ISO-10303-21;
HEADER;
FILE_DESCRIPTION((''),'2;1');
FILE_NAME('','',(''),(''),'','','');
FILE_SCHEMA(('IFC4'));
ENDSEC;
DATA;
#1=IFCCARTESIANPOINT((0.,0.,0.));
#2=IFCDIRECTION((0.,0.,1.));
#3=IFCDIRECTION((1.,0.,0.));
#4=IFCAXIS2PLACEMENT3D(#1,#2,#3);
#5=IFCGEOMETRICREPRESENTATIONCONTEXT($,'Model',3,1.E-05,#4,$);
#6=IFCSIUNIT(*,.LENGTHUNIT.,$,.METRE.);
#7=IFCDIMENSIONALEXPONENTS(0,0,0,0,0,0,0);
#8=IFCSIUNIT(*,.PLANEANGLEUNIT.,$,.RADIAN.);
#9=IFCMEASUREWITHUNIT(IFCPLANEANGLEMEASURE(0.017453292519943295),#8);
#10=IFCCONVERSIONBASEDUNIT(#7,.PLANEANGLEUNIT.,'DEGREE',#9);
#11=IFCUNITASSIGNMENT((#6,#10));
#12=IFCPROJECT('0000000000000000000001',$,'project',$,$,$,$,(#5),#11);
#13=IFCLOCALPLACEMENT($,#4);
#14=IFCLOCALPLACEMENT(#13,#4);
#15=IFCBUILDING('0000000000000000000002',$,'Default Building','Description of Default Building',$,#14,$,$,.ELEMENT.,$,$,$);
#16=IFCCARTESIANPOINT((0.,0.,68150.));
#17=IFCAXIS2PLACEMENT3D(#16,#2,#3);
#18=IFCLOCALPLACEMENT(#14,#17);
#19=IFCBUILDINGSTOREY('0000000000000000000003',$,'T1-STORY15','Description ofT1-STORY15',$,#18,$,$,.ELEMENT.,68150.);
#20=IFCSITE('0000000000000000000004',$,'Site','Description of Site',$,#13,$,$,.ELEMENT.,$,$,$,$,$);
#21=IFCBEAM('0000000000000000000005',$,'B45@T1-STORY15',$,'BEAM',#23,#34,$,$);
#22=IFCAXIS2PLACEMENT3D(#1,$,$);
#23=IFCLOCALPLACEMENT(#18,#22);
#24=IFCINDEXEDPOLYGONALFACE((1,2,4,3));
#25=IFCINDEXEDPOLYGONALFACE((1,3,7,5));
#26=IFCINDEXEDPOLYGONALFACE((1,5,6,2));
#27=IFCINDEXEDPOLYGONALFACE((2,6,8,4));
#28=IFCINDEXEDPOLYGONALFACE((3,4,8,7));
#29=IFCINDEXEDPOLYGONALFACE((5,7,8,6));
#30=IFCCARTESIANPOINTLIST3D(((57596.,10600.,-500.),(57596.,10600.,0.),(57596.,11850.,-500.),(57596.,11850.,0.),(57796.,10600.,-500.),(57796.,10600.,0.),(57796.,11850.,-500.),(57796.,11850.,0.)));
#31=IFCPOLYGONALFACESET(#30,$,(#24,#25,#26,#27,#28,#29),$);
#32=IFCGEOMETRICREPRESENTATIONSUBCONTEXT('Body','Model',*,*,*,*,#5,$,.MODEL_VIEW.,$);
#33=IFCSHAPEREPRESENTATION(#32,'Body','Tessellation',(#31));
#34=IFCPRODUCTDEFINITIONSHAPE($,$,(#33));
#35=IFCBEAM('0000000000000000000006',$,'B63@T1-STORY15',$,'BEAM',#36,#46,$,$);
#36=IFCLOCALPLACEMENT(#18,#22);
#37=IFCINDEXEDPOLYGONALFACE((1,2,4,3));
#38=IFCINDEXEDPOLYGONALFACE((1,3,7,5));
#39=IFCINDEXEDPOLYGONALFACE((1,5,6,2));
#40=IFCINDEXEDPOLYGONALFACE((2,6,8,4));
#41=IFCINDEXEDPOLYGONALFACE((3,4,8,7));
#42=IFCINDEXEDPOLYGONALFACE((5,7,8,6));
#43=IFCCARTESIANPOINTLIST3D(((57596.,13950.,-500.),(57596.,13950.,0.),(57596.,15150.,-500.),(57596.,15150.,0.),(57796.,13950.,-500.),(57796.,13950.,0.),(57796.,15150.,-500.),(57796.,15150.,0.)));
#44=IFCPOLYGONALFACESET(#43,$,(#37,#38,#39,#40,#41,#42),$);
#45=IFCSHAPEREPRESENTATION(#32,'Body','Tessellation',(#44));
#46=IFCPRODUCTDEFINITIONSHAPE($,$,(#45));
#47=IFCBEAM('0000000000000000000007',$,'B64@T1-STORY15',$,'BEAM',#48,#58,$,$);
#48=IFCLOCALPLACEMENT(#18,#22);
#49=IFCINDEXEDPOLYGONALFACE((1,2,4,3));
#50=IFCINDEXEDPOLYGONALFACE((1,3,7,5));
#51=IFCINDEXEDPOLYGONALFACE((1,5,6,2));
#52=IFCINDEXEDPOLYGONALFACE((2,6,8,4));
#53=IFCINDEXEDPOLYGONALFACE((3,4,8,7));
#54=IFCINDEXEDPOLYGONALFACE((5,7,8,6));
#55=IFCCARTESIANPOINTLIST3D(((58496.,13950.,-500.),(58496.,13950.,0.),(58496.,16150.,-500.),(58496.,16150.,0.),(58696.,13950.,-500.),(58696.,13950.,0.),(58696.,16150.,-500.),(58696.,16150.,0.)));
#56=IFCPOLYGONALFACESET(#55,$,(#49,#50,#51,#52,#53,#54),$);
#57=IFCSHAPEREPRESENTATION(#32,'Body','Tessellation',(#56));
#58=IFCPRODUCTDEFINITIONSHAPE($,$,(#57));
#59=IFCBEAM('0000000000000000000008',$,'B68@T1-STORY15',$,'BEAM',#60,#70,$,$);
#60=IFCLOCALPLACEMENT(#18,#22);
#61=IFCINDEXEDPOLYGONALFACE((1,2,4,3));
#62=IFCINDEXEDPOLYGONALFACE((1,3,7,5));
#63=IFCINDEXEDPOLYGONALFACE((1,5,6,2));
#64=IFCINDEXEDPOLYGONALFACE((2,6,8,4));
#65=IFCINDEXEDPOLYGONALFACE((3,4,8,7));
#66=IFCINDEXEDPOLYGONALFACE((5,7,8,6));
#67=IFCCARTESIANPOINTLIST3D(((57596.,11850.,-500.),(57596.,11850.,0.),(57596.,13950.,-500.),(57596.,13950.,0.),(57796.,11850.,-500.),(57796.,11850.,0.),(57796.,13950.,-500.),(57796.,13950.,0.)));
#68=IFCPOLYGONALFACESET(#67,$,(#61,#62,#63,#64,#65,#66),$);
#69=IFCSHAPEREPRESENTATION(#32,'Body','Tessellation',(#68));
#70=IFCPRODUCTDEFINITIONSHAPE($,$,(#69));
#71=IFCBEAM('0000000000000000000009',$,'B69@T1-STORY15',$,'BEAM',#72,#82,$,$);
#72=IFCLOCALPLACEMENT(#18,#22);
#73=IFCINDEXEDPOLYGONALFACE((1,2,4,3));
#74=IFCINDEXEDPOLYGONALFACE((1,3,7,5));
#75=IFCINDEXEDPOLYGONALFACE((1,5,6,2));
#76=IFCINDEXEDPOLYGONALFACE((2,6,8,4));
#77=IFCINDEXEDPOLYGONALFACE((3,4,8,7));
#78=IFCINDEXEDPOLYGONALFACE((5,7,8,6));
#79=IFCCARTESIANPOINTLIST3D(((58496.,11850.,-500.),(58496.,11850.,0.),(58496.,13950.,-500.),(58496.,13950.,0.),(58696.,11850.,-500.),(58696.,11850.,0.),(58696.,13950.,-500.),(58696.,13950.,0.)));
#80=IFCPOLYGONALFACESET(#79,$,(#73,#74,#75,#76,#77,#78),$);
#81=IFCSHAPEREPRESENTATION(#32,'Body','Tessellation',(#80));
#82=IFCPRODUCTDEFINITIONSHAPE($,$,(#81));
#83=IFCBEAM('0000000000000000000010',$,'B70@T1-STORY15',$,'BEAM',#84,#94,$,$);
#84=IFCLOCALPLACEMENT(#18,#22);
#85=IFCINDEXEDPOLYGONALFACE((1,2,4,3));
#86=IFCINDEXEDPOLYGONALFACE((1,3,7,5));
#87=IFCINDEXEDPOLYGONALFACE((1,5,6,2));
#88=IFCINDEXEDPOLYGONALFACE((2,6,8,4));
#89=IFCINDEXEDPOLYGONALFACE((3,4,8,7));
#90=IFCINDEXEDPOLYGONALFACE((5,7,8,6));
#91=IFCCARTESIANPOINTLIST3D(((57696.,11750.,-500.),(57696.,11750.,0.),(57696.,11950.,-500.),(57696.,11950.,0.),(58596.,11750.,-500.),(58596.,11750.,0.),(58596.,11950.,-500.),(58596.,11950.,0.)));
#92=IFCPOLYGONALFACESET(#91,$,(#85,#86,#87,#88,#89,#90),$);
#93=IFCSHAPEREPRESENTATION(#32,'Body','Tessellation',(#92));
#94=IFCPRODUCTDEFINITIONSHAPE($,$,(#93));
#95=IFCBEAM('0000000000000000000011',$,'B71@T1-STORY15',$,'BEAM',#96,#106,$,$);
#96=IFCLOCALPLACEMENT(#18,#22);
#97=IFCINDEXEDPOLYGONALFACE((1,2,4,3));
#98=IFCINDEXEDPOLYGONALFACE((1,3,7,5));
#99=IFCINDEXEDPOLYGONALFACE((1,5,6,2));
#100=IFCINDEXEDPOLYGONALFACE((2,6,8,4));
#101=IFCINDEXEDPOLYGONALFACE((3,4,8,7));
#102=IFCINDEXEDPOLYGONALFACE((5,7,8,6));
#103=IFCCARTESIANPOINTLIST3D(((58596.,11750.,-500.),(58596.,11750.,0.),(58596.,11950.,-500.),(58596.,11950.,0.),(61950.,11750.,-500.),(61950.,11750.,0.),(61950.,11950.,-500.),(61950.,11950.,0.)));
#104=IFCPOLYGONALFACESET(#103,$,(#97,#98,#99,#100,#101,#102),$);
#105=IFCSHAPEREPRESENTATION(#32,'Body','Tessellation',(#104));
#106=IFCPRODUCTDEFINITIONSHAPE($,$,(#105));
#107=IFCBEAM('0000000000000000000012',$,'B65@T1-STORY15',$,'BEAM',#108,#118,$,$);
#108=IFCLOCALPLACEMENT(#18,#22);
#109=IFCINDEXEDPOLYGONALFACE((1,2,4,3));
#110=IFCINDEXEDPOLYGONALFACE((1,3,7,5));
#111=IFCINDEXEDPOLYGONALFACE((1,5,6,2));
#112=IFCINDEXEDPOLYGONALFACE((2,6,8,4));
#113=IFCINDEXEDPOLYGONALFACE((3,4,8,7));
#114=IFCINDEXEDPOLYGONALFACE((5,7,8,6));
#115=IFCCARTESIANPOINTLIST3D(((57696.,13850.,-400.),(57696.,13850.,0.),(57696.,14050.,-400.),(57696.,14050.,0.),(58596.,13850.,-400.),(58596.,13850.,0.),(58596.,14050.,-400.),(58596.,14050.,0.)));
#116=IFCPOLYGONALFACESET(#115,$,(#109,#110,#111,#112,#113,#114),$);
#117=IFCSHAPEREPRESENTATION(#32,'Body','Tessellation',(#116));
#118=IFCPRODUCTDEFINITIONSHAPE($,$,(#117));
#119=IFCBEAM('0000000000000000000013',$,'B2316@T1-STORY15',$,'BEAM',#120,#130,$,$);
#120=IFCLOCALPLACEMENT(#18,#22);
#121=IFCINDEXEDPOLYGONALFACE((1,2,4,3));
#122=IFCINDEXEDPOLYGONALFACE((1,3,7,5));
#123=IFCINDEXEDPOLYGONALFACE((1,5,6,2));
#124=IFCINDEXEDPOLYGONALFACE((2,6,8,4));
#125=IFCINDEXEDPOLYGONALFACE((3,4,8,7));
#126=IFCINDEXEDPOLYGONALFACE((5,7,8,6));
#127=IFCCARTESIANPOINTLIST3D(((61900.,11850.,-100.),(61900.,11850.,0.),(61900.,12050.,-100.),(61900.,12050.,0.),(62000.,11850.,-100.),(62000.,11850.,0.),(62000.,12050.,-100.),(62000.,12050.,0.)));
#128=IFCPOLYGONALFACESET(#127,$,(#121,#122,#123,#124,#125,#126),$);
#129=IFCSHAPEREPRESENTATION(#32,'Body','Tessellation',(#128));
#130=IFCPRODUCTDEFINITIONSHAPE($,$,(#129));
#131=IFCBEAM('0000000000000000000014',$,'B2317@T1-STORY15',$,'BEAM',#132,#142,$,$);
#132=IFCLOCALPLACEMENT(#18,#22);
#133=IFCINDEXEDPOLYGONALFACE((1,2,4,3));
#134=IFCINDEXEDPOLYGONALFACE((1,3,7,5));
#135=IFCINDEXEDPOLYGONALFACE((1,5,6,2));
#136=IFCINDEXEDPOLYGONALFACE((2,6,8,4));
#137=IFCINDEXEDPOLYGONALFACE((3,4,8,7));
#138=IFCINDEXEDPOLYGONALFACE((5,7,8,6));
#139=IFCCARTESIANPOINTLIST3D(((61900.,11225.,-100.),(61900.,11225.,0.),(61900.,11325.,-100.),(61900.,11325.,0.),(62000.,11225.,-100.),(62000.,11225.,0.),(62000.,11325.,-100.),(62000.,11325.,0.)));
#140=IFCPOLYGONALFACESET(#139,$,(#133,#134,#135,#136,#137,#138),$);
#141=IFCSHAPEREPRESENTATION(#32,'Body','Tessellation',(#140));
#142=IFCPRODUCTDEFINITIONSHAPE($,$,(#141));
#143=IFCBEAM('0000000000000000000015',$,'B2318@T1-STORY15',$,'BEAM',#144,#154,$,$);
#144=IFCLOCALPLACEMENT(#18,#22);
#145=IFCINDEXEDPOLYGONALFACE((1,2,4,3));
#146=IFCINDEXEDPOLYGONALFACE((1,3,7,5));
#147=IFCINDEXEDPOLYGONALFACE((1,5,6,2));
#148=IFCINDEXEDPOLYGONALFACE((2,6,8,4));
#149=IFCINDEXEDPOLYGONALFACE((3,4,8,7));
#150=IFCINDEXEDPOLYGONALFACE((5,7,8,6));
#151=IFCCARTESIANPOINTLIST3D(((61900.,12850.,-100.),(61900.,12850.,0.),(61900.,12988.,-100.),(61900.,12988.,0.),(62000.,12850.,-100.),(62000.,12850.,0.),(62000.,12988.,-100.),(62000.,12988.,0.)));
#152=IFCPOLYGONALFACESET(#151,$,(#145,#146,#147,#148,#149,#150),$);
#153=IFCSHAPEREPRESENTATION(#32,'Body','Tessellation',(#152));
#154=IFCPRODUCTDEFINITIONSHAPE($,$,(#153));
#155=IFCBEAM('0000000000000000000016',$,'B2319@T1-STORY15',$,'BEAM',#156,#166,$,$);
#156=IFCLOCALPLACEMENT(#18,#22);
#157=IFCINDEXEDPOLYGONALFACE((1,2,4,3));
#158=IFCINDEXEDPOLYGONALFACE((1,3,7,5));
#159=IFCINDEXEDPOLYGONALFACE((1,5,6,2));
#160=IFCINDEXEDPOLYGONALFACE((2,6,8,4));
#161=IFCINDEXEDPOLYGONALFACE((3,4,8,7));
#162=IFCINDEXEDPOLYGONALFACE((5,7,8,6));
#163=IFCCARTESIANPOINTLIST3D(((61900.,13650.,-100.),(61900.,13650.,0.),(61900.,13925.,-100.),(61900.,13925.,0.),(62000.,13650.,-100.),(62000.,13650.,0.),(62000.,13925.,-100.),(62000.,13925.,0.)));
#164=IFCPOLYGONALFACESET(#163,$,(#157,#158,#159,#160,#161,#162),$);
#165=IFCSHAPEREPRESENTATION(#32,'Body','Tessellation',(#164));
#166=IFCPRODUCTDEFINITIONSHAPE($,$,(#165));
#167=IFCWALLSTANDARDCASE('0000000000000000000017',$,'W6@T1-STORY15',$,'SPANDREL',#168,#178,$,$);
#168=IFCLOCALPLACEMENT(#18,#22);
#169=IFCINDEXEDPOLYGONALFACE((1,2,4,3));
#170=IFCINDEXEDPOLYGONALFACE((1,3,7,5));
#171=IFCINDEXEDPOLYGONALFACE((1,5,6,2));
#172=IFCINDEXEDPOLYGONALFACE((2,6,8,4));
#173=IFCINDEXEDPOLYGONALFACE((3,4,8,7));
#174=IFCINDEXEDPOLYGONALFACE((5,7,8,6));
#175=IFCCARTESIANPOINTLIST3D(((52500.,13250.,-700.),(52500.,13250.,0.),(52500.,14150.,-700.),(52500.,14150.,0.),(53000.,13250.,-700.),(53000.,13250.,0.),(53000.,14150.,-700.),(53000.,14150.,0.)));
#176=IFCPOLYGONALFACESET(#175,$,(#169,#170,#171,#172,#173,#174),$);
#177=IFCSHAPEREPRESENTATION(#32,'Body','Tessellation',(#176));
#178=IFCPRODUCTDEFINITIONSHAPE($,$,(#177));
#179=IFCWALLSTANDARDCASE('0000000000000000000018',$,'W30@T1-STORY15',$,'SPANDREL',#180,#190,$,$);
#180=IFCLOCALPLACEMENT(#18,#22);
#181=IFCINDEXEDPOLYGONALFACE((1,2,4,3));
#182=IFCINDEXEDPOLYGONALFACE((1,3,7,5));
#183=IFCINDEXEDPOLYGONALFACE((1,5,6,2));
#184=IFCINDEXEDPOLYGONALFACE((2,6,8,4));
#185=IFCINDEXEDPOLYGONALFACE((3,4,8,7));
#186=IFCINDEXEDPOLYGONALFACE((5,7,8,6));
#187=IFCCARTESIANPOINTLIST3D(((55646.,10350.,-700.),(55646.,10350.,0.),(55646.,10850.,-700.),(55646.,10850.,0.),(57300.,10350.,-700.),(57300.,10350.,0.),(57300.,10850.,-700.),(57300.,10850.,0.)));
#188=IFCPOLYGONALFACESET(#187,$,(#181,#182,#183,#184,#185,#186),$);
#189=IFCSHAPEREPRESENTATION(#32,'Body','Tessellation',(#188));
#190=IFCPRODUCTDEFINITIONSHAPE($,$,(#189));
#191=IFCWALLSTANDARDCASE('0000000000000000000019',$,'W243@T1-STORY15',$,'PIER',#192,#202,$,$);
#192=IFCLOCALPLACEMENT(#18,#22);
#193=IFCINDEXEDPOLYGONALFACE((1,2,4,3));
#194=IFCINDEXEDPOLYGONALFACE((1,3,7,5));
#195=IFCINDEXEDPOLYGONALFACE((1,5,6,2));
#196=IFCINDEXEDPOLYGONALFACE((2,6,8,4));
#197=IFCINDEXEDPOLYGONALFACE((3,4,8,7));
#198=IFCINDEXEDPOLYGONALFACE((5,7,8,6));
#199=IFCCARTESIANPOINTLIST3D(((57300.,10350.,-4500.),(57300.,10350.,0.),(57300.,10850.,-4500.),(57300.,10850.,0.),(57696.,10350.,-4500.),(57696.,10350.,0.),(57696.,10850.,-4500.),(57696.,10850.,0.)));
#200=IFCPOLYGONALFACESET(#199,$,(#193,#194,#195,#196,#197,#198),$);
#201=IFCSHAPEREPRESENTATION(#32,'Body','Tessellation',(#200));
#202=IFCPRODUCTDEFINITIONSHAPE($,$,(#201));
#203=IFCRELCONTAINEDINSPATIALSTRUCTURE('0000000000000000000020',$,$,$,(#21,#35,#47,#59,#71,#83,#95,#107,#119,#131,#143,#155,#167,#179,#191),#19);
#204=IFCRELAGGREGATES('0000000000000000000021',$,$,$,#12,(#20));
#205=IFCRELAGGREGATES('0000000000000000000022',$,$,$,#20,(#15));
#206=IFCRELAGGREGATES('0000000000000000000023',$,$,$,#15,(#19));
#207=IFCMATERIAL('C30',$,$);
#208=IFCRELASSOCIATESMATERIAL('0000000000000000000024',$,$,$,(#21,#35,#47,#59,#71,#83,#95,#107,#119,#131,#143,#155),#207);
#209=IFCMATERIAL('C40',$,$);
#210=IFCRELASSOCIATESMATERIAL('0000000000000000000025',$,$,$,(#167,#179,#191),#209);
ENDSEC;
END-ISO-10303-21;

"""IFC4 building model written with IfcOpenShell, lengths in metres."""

from ifc_helpers import new_model, entity, si_unit, converted_unit, frame, origin_with_axes, place, context, subcontext, project, spatial, indexed_curve, rectangle, outline, extrude, material, element, save


model = new_model("IFC4")

# Units and contexts
model_context = context("Model", 3, precision=1e-05, world=origin_with_axes())
body_context = subcontext(model_context, "Body", "Model", "MODEL_VIEW")
ifc_project = project(units=[si_unit("LENGTHUNIT", "METRE"), converted_unit("PLANEANGLEUNIT", "DEGREE", entity("IfcPlaneAngleMeasure", 0.017453292519943295), si_unit("PLANEANGLEUNIT", "RADIAN"), dimensions=[0, 0, 0, 0, 0, 0, 0])], contexts=[model_context])

# Site, building, storey
site_placement = place(None, origin_with_axes())
site = spatial("IfcSite", under=ifc_project, at=site_placement, Name="Site", Description="Description of Site", CompositionType="ELEMENT")
building_placement = place(site_placement, origin_with_axes())
building = spatial("IfcBuilding", under=site, at=building_placement, Name="Default Building", Description="Description of Default Building", CompositionType="ELEMENT")
storey_placement = place(building_placement, frame((0.0, 0.0, 68150.0), z_axis=(0.0, 0.0, 1.0), x_axis=(1.0, 0.0, 0.0)))
storey = spatial("IfcBuildingStorey", under=building, at=storey_placement, Name="T1-STORY15", Description="Description ofT1-STORY15", CompositionType="ELEMENT", Elevation=68150.0)

# Beams
ifc_material_1 = material(Name="C30")
beam_1_placement = place(storey_placement, frame((57696.0, 10600.0, -250.0), z_axis=(0.0, 1.0, 0.0), x_axis=(-1.0, 0.0, 0.0)))
element("IfcBeam", 1, at=beam_1_placement, inside=storey, material=ifc_material_1, Name="B45@T1-STORY15", ObjectType="BEAM", context=body_context, shape_type="SweptSolid", body=[
    extrude(rectangle(XDim=200.0, YDim=500.0), origin_with_axes(), (0.0, 0.0, 1.0), 1250.0),
])
beam_2_placement = place(storey_placement, frame((57696.0, 13950.0, -250.0), z_axis=(0.0, 1.0, 0.0), x_axis=(-1.0, 0.0, 0.0)))
element("IfcBeam", 2, at=beam_2_placement, inside=storey, material=ifc_material_1, Name="B63@T1-STORY15", ObjectType="BEAM", context=body_context, shape_type="SweptSolid", body=[
    extrude(rectangle(XDim=200.0, YDim=500.0), origin_with_axes(), (0.0, 0.0, 1.0), 1200.0),
])
beam_3_placement = place(storey_placement, frame((58596.0, 13950.0, -250.0), z_axis=(0.0, 1.0, 0.0), x_axis=(-1.0, 0.0, 0.0)))
element("IfcBeam", 3, at=beam_3_placement, inside=storey, material=ifc_material_1, Name="B64@T1-STORY15", ObjectType="BEAM", context=body_context, shape_type="SweptSolid", body=[
    extrude(rectangle(XDim=200.0, YDim=500.0), origin_with_axes(), (0.0, 0.0, 1.0), 2200.0),
])
for number, where, z_axis, x_axis, name in (
    (4, (57696.0, 11850.0, -250.0), (0.0, 1.0, 0.0), (-1.0, 0.0, 0.0), "B68@T1-STORY15"),
    (5, (58596.0, 11850.0, -250.0), (0.0, 1.0, 0.0), (-1.0, 0.0, 0.0), "B69@T1-STORY15"),
):
    element("IfcBeam", number, at=place(storey_placement, frame(where, z_axis=z_axis, x_axis=x_axis)), inside=storey, material=ifc_material_1, Name=name, ObjectType="BEAM", context=body_context, shape_type="SweptSolid", body=[
        extrude(rectangle(XDim=200.0, YDim=500.0), origin_with_axes(), (0.0, 0.0, 1.0), 2100.0),
    ])
beam_4_placement = place(storey_placement, frame((57696.0, 11850.0, -250.0), z_axis=(1.0, 0.0, 0.0), x_axis=(0.0, 1.0, 0.0)))
element("IfcBeam", 6, at=beam_4_placement, inside=storey, material=ifc_material_1, Name="B70@T1-STORY15", ObjectType="BEAM", context=body_context, shape_type="SweptSolid", body=[
    extrude(rectangle(XDim=200.0, YDim=500.0), origin_with_axes(), (0.0, 0.0, 1.0), 900.0),
])
beam_5_placement = place(storey_placement, frame((58596.0, 11850.0, -250.0), z_axis=(1.0, 0.0, 0.0), x_axis=(0.0, 1.0, 0.0)))
element("IfcBeam", 7, at=beam_5_placement, inside=storey, material=ifc_material_1, Name="B71@T1-STORY15", ObjectType="BEAM", context=body_context, shape_type="SweptSolid", body=[
    extrude(rectangle(XDim=200.0, YDim=500.0), origin_with_axes(), (0.0, 0.0, 1.0), 3354.0),
])
beam_6_placement = place(storey_placement, frame((57696.0, 13950.0, -200.0), z_axis=(1.0, 0.0, 0.0), x_axis=(0.0, 1.0, 0.0)))
element("IfcBeam", 8, at=beam_6_placement, inside=storey, material=ifc_material_1, Name="B65@T1-STORY15", ObjectType="BEAM", context=body_context, shape_type="SweptSolid", body=[
    extrude(rectangle(XDim=200.0, YDim=400.0), origin_with_axes(), (0.0, 0.0, 1.0), 900.0),
])
beam_7_placement = place(storey_placement, frame((61950.0, 11850.0, -50.0), z_axis=(0.0, 1.0, 0.0), x_axis=(-1.0, 0.0, 0.0)))
element("IfcBeam", 9, at=beam_7_placement, inside=storey, material=ifc_material_1, Name="B2316@T1-STORY15", ObjectType="BEAM", context=body_context, shape_type="SweptSolid", body=[
    extrude(rectangle(XDim=100.0, YDim=100.0), origin_with_axes(), (0.0, 0.0, 1.0), 200.0),
])
beam_8_placement = place(storey_placement, frame((61950.0, 11225.0, -50.0), z_axis=(0.0, 1.0, 0.0), x_axis=(-1.0, 0.0, 0.0)))
element("IfcBeam", 10, at=beam_8_placement, inside=storey, material=ifc_material_1, Name="B2317@T1-STORY15", ObjectType="BEAM", context=body_context, shape_type="SweptSolid", body=[
    extrude(rectangle(XDim=100.0, YDim=100.0), origin_with_axes(), (0.0, 0.0, 1.0), 100.0),
])
beam_9_placement = place(storey_placement, frame((61950.0, 12850.0, -50.0), z_axis=(0.0, 1.0, 0.0), x_axis=(-1.0, 0.0, 0.0)))
element("IfcBeam", 11, at=beam_9_placement, inside=storey, material=ifc_material_1, Name="B2318@T1-STORY15", ObjectType="BEAM", context=body_context, shape_type="SweptSolid", body=[
    extrude(rectangle(XDim=100.0, YDim=100.0), origin_with_axes(), (0.0, 0.0, 1.0), 138.0),
])
beam_10_placement = place(storey_placement, frame((61950.0, 13650.0, -50.0), z_axis=(0.0, 1.0, 0.0), x_axis=(-1.0, 0.0, 0.0)))
element("IfcBeam", 12, at=beam_10_placement, inside=storey, material=ifc_material_1, Name="B2319@T1-STORY15", ObjectType="BEAM", context=body_context, shape_type="SweptSolid", body=[
    extrude(rectangle(XDim=100.0, YDim=100.0), origin_with_axes(), (0.0, 0.0, 1.0), 275.0),
])

# Walls
ifc_material_2 = material(Name="C40")
wall_1_placement = place(storey_placement, frame((52750.0, 13250.0, -700.0), z_axis=(0.0, 0.0, 1.0), x_axis=(0.0, 1.0, 0.0)))
element("IfcWallStandardCase", 13, at=wall_1_placement, inside=storey, material=ifc_material_2, Name="W6@T1-STORY15", ObjectType="SPANDREL", context=body_context, shape_type="SweptSolid", body=[
    extrude(outline(indexed_curve([(0.0, -250.0), (0.0, 250.0), (900.0, 250.0), (900.0, -250.0), (0.0, -250.0)], self_intersect=False)), origin_with_axes(), (0.0, 0.0, 1.0), 700.0),
])
wall_2_placement = place(storey_placement, frame((55646.0, 10600.0, -700.0), z_axis=(0.0, 0.0, 1.0), x_axis=(1.0, 0.0, 0.0)))
element("IfcWallStandardCase", 14, at=wall_2_placement, inside=storey, material=ifc_material_2, Name="W30@T1-STORY15", ObjectType="SPANDREL", context=body_context, shape_type="SweptSolid", body=[
    extrude(outline(indexed_curve([(0.0, -250.0), (0.0, 250.0), (1654.0, 250.0), (1654.0, -250.0), (0.0, -250.0)], self_intersect=False)), origin_with_axes(), (0.0, 0.0, 1.0), 700.0),
])
wall_3_placement = place(storey_placement, frame((57300.0, 10600.0, -4500.0), z_axis=(0.0, 0.0, 1.0), x_axis=(1.0, 0.0, 0.0)))
element("IfcWallStandardCase", 15, at=wall_3_placement, inside=storey, material=ifc_material_2, Name="W243@T1-STORY15", ObjectType="PIER", context=body_context, shape_type="SweptSolid", body=[
    extrude(outline(indexed_curve([(0.0, -250.0), (0.0, 250.0), (396.0, 250.0), (396.0, -250.0), (0.0, -250.0)], self_intersect=False)), origin_with_axes(), (0.0, 0.0, 1.0), 4500.0),
])

save(model, "model.ifc")
